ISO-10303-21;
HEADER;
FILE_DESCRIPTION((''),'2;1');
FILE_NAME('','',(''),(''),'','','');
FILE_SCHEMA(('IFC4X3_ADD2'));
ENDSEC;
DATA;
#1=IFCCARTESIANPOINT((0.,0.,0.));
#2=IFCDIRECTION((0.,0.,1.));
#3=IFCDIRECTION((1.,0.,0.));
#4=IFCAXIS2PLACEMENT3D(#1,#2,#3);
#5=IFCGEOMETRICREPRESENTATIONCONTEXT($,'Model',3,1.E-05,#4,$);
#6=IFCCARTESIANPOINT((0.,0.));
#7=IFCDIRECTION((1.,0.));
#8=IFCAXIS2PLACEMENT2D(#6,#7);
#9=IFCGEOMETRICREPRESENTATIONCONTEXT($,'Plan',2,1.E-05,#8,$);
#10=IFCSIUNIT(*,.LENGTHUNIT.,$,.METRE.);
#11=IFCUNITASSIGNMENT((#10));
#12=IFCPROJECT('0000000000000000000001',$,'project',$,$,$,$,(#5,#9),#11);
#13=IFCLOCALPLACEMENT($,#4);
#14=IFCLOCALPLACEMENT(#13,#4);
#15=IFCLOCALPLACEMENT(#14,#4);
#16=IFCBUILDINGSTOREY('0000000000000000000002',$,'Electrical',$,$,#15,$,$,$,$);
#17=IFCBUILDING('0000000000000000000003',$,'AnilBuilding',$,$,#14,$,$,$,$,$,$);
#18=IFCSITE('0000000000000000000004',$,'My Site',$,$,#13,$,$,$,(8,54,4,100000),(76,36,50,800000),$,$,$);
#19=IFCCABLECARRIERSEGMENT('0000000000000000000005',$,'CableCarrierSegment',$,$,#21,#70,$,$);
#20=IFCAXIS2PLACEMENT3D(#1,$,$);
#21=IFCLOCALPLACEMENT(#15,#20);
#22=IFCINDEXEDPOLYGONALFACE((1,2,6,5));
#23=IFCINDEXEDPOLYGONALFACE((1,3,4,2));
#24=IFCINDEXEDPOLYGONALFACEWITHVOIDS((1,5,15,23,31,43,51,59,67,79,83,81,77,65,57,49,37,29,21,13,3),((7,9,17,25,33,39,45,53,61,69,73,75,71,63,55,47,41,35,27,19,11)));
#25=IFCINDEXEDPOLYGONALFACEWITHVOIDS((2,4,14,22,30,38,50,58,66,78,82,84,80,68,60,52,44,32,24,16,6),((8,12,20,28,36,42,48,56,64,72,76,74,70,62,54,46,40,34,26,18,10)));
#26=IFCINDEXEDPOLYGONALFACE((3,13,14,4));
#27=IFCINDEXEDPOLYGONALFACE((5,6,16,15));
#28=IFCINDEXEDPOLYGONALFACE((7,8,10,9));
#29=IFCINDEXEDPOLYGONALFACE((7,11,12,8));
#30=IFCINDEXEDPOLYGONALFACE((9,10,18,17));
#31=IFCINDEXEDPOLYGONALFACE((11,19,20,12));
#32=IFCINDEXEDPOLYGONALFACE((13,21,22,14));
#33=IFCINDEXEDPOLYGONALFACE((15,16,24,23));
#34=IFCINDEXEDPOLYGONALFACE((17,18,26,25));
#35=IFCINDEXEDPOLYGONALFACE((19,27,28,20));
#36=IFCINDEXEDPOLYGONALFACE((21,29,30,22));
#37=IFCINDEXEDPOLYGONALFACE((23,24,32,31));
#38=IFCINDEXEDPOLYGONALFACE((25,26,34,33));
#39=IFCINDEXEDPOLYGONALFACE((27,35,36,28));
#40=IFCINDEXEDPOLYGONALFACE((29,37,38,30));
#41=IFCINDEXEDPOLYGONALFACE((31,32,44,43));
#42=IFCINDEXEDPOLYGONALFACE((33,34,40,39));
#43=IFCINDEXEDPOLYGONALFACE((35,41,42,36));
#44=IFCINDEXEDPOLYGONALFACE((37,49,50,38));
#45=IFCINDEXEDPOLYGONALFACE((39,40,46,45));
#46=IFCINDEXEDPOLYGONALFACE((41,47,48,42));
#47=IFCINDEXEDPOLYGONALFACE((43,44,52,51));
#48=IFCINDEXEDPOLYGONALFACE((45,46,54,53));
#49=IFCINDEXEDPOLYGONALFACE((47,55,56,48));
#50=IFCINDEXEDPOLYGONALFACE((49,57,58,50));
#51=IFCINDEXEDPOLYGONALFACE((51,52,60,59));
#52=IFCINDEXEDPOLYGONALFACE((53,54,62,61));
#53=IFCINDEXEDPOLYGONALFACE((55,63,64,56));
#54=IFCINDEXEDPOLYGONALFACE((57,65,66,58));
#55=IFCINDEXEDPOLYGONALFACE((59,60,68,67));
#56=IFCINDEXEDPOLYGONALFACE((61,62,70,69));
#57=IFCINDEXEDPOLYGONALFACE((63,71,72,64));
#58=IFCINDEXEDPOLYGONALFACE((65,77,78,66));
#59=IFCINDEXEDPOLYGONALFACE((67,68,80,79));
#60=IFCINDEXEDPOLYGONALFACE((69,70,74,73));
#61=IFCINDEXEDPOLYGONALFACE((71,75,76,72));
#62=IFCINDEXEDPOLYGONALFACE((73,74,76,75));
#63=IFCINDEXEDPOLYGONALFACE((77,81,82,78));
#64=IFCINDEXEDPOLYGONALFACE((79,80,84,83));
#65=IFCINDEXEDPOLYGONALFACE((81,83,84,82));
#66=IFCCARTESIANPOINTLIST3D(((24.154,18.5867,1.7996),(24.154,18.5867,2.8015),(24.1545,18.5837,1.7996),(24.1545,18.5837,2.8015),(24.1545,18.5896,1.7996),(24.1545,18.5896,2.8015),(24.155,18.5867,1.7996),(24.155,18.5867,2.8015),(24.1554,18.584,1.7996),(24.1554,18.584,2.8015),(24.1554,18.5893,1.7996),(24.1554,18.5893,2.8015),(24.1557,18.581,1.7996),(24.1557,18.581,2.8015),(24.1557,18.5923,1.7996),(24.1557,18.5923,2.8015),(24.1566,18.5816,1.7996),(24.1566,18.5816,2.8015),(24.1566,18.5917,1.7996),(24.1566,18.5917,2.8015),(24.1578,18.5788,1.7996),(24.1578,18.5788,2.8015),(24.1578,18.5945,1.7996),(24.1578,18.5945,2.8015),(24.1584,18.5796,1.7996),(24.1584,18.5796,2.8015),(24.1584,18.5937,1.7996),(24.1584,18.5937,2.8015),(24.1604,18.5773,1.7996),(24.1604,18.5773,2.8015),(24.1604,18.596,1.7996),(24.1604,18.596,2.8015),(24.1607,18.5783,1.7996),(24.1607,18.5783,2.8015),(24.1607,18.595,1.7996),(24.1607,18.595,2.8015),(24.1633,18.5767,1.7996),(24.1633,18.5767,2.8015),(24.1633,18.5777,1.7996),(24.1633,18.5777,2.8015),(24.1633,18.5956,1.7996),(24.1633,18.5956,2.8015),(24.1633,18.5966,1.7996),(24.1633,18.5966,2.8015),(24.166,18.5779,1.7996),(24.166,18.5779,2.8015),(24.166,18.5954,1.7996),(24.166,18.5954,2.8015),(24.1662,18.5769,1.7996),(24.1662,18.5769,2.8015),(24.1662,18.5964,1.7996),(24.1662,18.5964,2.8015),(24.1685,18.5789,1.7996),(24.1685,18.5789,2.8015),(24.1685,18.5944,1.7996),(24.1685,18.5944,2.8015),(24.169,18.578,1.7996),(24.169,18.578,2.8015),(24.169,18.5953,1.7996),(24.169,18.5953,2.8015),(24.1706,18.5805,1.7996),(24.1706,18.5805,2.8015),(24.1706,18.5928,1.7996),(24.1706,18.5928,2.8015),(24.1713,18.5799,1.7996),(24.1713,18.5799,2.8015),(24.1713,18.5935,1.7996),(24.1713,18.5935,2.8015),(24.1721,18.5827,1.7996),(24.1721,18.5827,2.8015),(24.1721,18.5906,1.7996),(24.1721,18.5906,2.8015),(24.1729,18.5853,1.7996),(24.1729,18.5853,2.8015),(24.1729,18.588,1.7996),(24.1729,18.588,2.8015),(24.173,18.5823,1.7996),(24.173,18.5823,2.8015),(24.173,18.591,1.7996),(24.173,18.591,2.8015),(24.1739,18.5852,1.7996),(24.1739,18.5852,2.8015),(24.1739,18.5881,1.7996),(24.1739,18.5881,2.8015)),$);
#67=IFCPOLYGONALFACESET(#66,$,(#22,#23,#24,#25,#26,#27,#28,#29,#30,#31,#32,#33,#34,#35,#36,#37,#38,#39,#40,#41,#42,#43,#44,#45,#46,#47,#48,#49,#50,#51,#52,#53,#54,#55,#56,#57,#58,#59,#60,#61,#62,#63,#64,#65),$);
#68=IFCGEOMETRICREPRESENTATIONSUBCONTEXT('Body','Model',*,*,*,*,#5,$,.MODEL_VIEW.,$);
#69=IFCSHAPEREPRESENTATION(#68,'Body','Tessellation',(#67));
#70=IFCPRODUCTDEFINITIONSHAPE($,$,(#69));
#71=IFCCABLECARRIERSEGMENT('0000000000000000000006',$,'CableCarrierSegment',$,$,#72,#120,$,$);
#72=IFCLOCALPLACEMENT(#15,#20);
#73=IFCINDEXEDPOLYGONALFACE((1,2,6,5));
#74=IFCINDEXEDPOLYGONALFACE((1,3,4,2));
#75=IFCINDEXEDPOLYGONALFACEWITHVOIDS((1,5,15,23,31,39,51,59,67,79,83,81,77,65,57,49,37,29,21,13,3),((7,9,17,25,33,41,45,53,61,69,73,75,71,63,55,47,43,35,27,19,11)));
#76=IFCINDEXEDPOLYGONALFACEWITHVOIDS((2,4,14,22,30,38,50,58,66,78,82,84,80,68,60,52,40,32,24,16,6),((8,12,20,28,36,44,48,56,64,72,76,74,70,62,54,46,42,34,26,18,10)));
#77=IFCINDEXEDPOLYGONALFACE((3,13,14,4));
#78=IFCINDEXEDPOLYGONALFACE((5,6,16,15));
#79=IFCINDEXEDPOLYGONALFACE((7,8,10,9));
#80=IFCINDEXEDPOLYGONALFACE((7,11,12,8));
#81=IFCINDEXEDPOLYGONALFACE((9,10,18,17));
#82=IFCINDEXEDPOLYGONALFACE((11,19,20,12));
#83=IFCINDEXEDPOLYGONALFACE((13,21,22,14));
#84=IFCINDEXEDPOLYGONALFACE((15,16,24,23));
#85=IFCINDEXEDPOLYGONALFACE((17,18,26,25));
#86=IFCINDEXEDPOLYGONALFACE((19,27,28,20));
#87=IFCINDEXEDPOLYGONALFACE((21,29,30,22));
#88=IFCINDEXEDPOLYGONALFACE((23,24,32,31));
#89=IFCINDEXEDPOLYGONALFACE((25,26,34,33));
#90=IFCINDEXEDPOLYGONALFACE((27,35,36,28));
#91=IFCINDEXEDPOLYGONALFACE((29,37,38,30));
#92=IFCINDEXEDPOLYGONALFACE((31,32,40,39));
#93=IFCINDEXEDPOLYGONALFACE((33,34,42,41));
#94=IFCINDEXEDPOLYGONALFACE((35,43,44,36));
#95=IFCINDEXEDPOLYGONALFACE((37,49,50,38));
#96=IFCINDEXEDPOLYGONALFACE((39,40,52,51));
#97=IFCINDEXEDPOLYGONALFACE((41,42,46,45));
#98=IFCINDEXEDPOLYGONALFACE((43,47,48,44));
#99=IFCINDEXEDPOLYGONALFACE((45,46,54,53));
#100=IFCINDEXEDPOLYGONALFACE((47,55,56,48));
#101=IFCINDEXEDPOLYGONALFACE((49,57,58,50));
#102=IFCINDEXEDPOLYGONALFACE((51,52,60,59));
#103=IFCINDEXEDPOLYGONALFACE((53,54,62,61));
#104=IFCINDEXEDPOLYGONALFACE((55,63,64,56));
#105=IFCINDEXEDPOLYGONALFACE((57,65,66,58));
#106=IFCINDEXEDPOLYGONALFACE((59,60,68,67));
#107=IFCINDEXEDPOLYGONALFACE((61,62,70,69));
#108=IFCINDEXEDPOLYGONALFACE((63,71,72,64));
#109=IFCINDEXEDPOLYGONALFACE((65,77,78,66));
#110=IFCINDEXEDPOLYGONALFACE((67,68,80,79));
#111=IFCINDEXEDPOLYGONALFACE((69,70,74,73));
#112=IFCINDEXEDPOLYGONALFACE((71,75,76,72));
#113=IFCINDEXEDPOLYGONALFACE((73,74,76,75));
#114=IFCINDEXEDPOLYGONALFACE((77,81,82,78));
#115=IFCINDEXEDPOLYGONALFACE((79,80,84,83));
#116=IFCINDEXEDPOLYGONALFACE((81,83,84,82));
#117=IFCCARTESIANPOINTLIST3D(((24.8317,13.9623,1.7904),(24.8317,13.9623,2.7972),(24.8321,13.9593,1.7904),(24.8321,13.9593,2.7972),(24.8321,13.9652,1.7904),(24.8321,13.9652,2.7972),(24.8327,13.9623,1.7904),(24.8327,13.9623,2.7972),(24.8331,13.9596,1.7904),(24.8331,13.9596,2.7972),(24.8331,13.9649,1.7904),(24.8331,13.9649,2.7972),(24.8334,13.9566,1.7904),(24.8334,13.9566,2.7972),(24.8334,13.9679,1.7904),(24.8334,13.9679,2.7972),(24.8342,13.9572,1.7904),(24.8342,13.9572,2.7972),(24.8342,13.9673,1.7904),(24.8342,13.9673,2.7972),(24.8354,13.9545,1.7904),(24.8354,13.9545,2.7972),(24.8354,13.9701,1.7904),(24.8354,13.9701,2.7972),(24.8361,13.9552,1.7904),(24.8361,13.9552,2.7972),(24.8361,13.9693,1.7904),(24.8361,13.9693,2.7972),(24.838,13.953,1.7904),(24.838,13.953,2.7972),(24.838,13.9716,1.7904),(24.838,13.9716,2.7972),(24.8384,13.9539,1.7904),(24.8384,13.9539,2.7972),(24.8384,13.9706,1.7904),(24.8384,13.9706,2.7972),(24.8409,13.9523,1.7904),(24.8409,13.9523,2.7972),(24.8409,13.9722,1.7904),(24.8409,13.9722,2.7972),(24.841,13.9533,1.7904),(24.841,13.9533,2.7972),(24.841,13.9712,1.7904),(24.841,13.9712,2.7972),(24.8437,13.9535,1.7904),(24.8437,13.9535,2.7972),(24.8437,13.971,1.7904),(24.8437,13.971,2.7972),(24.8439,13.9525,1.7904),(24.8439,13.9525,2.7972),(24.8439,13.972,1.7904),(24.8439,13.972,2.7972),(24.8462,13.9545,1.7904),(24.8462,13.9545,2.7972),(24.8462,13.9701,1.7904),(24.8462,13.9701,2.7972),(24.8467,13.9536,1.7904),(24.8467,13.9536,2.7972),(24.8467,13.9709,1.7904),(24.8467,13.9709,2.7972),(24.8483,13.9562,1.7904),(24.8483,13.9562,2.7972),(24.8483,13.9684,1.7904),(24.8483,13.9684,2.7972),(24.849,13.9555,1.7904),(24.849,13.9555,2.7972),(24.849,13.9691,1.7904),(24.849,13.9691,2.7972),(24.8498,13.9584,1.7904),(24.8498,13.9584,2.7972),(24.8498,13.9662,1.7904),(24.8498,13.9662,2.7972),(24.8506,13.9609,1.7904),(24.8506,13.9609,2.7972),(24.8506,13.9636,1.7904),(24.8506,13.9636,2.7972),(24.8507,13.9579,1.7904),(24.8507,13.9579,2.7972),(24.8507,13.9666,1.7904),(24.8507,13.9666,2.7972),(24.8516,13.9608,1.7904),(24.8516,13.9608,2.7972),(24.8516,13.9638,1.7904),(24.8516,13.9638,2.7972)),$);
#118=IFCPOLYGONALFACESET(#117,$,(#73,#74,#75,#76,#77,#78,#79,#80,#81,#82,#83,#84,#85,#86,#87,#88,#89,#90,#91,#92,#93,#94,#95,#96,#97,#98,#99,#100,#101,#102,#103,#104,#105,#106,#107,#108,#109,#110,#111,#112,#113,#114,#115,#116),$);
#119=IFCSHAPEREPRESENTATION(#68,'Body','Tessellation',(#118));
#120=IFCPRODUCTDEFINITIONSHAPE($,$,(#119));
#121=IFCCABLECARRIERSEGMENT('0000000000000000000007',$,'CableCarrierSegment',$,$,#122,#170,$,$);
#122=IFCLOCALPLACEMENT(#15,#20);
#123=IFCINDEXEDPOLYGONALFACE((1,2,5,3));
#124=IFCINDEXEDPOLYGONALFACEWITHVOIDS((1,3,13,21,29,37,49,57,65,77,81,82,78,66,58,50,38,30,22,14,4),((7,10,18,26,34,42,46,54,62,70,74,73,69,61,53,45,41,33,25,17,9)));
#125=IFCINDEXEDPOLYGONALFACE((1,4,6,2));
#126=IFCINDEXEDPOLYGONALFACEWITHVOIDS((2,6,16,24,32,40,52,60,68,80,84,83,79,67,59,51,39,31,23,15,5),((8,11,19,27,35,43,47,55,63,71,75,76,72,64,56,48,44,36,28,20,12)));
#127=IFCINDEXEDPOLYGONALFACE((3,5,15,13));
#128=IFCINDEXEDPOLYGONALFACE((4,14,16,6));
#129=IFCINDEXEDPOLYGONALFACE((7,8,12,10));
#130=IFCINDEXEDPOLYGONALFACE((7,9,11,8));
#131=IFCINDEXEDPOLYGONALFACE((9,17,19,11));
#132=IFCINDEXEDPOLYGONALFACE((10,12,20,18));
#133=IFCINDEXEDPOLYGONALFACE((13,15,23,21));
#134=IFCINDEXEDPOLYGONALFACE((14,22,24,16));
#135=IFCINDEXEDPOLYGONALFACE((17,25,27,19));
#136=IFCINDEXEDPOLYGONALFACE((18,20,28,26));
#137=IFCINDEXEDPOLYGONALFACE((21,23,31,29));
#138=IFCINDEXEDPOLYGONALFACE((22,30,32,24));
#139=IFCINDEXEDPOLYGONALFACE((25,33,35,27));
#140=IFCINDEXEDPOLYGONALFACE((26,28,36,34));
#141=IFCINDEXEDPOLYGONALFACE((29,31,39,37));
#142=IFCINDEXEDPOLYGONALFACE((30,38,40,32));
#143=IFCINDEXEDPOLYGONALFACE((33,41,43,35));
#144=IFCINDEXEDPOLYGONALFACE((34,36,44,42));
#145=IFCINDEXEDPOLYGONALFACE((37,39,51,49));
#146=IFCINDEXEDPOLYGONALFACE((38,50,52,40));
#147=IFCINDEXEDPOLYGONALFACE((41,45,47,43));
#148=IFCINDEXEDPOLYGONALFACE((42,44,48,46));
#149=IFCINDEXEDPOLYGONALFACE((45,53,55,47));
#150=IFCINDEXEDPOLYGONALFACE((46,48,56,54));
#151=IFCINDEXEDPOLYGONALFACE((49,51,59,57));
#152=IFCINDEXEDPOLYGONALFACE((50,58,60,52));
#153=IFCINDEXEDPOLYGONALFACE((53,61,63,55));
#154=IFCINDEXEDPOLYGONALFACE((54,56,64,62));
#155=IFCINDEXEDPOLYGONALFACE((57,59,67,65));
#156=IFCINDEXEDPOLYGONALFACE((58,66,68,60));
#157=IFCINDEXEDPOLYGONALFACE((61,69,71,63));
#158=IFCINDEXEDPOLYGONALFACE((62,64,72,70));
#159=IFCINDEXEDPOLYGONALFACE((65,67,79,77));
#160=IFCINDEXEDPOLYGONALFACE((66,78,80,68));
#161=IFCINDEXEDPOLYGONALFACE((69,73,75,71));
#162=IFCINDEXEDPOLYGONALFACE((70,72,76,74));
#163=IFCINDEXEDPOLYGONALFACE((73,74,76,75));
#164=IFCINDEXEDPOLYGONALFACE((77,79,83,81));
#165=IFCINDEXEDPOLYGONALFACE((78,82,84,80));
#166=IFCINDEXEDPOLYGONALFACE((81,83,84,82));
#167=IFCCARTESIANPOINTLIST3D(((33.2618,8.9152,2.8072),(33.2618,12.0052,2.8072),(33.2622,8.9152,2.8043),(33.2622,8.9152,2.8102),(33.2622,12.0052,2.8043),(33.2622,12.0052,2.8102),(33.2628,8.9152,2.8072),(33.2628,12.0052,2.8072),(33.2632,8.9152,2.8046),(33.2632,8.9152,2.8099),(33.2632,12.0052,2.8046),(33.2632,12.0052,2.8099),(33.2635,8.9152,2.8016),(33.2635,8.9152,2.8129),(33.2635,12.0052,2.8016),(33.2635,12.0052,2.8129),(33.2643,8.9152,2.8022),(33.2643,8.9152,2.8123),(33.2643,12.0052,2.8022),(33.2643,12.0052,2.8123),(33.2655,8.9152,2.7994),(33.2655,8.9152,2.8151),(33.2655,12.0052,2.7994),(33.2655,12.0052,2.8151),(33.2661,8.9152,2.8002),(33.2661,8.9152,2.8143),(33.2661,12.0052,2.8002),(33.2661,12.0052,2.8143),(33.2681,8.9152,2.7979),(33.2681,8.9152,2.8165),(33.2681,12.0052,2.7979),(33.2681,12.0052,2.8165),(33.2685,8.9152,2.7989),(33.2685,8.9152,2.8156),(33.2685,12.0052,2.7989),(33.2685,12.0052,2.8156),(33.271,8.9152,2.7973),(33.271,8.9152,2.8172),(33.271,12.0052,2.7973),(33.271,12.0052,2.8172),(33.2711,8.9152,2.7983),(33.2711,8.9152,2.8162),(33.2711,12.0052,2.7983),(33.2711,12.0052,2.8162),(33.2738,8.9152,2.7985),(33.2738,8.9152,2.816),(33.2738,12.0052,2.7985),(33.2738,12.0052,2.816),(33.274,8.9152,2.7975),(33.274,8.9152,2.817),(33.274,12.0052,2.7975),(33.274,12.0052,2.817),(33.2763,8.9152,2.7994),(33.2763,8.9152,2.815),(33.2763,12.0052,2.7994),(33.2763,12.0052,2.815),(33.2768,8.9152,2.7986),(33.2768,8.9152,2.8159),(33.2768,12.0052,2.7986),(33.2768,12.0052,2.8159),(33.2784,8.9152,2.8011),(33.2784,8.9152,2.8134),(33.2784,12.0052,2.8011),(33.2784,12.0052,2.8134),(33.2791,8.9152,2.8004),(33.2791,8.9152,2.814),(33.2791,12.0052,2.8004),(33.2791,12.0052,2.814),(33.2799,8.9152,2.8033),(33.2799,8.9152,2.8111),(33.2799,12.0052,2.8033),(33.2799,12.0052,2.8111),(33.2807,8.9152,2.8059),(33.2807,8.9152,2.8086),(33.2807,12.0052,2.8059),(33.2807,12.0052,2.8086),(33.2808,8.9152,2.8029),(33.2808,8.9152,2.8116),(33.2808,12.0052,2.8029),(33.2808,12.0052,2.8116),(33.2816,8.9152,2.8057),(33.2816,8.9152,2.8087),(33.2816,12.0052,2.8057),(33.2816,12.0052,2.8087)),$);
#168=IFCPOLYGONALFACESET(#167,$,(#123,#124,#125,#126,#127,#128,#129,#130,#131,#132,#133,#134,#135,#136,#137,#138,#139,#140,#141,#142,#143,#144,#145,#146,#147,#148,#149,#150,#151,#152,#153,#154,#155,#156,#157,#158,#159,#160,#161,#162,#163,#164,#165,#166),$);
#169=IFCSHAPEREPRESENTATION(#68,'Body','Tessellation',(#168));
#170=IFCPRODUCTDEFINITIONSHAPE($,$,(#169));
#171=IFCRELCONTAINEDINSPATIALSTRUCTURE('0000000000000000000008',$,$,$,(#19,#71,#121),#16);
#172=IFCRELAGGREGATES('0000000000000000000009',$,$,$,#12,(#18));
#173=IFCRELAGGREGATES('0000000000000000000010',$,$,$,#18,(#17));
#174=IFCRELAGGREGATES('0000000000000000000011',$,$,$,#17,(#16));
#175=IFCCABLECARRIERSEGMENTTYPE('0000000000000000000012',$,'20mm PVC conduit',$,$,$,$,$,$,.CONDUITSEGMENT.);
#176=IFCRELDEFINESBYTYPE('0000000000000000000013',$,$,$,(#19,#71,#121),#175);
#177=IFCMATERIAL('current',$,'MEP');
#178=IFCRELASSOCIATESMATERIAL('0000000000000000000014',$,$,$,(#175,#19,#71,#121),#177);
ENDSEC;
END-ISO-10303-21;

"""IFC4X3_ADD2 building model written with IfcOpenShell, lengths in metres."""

from ifc_helpers import new_model, si_unit, frame, origin_with_axes, origin_2d_with_axis, place, context, subcontext, project, spatial, hollow_circle, extrude, material, material_profile, profile_set, profile_usage, type_object, element, save


model = new_model("IFC4X3_ADD2")

# Units and contexts
model_context = context("Model", 3, precision=1e-05, world=origin_with_axes())
plan_context = context("Plan", 2, precision=1e-05, world=origin_2d_with_axis())
body_context = subcontext(model_context, "Body", "Model", "MODEL_VIEW")
ifc_project = project(units=[si_unit("LENGTHUNIT", "METRE")], contexts=[model_context, plan_context])

# Site, building, storey
site_placement = place(None, origin_with_axes())
site = spatial("IfcSite", under=ifc_project, at=site_placement, Name="My Site", RefLatitude=(8, 54, 4, 100000), RefLongitude=(76, 36, 50, 800000))
building_placement = place(site_placement, origin_with_axes())
building = spatial("IfcBuilding", under=site, at=building_placement, Name="AnilBuilding")
storey_placement = place(building_placement, origin_with_axes())
storey = spatial("IfcBuildingStorey", under=building, at=storey_placement, Name="Electrical")

# Cable carrier segments
ifc_material = material(Name="current", Category="MEP")
ifc_material_profile_1 = material_profile(ifc_material, hollow_circle(Radius=0.01, WallThickness=0.001))
ifc_profile_set_1 = profile_set([ifc_material_profile_1], Name="current")
ifc_profile_usage_1 = profile_usage(ifc_profile_set_1, cardinal=5)
ifc_material_profile_2 = material_profile(ifc_material, hollow_circle(Radius=0.01, WallThickness=0.001))
ifc_profile_set_2 = profile_set([ifc_material_profile_2], Name="current")
cable_carrier_segment_type = type_object("IfcCableCarrierSegmentType", Name="20mm PVC conduit", PredefinedType="CONDUITSEGMENT", material=ifc_profile_set_2)
cable_carrier_segment_1_placement = place(storey_placement, frame((24.164, 18.5867, 1.7996), z_axis=(0.0, 0.0, 1.0), x_axis=(-1.0, 0.0, 0.0)))
element("IfcCableCarrierSegment", 1, at=cable_carrier_segment_1_placement, inside=storey, type_object=cable_carrier_segment_type, material=ifc_profile_usage_1, Name="CableCarrierSegment", context=body_context, shape_type="SweptSolid", body=[
    extrude(hollow_circle(Radius=0.01, WallThickness=0.001), origin_with_axes(), (0.0, 0.0, 1.0), 1.0019),
])
ifc_profile_usage_2 = profile_usage(ifc_profile_set_1, cardinal=5)
cable_carrier_segment_2_placement = place(storey_placement, frame((24.8417, 13.9623, 1.7904), z_axis=(0.0, 0.0, 1.0), x_axis=(-1.0, 0.0, 0.0)))
element("IfcCableCarrierSegment", 2, at=cable_carrier_segment_2_placement, inside=storey, type_object=cable_carrier_segment_type, material=ifc_profile_usage_2, Name="CableCarrierSegment", context=body_context, shape_type="SweptSolid", body=[
    extrude(hollow_circle(Radius=0.01, WallThickness=0.001), origin_with_axes(), (0.0, 0.0, 1.0), 1.0068),
])
ifc_profile_usage_3 = profile_usage(ifc_profile_set_1, cardinal=5)
cable_carrier_segment_3_placement = place(storey_placement, frame((33.2718, 8.9152, 2.8072), z_axis=(0.0, 1.0, 0.0), x_axis=(-1.0, 0.0, 0.0)))
element("IfcCableCarrierSegment", 3, at=cable_carrier_segment_3_placement, inside=storey, type_object=cable_carrier_segment_type, material=ifc_profile_usage_3, Name="CableCarrierSegment", context=body_context, shape_type="SweptSolid", body=[
    extrude(hollow_circle(Radius=0.01, WallThickness=0.001), origin_with_axes(), (0.0, 0.0, 1.0), 3.09),
])

save(model, "model.ifc")
